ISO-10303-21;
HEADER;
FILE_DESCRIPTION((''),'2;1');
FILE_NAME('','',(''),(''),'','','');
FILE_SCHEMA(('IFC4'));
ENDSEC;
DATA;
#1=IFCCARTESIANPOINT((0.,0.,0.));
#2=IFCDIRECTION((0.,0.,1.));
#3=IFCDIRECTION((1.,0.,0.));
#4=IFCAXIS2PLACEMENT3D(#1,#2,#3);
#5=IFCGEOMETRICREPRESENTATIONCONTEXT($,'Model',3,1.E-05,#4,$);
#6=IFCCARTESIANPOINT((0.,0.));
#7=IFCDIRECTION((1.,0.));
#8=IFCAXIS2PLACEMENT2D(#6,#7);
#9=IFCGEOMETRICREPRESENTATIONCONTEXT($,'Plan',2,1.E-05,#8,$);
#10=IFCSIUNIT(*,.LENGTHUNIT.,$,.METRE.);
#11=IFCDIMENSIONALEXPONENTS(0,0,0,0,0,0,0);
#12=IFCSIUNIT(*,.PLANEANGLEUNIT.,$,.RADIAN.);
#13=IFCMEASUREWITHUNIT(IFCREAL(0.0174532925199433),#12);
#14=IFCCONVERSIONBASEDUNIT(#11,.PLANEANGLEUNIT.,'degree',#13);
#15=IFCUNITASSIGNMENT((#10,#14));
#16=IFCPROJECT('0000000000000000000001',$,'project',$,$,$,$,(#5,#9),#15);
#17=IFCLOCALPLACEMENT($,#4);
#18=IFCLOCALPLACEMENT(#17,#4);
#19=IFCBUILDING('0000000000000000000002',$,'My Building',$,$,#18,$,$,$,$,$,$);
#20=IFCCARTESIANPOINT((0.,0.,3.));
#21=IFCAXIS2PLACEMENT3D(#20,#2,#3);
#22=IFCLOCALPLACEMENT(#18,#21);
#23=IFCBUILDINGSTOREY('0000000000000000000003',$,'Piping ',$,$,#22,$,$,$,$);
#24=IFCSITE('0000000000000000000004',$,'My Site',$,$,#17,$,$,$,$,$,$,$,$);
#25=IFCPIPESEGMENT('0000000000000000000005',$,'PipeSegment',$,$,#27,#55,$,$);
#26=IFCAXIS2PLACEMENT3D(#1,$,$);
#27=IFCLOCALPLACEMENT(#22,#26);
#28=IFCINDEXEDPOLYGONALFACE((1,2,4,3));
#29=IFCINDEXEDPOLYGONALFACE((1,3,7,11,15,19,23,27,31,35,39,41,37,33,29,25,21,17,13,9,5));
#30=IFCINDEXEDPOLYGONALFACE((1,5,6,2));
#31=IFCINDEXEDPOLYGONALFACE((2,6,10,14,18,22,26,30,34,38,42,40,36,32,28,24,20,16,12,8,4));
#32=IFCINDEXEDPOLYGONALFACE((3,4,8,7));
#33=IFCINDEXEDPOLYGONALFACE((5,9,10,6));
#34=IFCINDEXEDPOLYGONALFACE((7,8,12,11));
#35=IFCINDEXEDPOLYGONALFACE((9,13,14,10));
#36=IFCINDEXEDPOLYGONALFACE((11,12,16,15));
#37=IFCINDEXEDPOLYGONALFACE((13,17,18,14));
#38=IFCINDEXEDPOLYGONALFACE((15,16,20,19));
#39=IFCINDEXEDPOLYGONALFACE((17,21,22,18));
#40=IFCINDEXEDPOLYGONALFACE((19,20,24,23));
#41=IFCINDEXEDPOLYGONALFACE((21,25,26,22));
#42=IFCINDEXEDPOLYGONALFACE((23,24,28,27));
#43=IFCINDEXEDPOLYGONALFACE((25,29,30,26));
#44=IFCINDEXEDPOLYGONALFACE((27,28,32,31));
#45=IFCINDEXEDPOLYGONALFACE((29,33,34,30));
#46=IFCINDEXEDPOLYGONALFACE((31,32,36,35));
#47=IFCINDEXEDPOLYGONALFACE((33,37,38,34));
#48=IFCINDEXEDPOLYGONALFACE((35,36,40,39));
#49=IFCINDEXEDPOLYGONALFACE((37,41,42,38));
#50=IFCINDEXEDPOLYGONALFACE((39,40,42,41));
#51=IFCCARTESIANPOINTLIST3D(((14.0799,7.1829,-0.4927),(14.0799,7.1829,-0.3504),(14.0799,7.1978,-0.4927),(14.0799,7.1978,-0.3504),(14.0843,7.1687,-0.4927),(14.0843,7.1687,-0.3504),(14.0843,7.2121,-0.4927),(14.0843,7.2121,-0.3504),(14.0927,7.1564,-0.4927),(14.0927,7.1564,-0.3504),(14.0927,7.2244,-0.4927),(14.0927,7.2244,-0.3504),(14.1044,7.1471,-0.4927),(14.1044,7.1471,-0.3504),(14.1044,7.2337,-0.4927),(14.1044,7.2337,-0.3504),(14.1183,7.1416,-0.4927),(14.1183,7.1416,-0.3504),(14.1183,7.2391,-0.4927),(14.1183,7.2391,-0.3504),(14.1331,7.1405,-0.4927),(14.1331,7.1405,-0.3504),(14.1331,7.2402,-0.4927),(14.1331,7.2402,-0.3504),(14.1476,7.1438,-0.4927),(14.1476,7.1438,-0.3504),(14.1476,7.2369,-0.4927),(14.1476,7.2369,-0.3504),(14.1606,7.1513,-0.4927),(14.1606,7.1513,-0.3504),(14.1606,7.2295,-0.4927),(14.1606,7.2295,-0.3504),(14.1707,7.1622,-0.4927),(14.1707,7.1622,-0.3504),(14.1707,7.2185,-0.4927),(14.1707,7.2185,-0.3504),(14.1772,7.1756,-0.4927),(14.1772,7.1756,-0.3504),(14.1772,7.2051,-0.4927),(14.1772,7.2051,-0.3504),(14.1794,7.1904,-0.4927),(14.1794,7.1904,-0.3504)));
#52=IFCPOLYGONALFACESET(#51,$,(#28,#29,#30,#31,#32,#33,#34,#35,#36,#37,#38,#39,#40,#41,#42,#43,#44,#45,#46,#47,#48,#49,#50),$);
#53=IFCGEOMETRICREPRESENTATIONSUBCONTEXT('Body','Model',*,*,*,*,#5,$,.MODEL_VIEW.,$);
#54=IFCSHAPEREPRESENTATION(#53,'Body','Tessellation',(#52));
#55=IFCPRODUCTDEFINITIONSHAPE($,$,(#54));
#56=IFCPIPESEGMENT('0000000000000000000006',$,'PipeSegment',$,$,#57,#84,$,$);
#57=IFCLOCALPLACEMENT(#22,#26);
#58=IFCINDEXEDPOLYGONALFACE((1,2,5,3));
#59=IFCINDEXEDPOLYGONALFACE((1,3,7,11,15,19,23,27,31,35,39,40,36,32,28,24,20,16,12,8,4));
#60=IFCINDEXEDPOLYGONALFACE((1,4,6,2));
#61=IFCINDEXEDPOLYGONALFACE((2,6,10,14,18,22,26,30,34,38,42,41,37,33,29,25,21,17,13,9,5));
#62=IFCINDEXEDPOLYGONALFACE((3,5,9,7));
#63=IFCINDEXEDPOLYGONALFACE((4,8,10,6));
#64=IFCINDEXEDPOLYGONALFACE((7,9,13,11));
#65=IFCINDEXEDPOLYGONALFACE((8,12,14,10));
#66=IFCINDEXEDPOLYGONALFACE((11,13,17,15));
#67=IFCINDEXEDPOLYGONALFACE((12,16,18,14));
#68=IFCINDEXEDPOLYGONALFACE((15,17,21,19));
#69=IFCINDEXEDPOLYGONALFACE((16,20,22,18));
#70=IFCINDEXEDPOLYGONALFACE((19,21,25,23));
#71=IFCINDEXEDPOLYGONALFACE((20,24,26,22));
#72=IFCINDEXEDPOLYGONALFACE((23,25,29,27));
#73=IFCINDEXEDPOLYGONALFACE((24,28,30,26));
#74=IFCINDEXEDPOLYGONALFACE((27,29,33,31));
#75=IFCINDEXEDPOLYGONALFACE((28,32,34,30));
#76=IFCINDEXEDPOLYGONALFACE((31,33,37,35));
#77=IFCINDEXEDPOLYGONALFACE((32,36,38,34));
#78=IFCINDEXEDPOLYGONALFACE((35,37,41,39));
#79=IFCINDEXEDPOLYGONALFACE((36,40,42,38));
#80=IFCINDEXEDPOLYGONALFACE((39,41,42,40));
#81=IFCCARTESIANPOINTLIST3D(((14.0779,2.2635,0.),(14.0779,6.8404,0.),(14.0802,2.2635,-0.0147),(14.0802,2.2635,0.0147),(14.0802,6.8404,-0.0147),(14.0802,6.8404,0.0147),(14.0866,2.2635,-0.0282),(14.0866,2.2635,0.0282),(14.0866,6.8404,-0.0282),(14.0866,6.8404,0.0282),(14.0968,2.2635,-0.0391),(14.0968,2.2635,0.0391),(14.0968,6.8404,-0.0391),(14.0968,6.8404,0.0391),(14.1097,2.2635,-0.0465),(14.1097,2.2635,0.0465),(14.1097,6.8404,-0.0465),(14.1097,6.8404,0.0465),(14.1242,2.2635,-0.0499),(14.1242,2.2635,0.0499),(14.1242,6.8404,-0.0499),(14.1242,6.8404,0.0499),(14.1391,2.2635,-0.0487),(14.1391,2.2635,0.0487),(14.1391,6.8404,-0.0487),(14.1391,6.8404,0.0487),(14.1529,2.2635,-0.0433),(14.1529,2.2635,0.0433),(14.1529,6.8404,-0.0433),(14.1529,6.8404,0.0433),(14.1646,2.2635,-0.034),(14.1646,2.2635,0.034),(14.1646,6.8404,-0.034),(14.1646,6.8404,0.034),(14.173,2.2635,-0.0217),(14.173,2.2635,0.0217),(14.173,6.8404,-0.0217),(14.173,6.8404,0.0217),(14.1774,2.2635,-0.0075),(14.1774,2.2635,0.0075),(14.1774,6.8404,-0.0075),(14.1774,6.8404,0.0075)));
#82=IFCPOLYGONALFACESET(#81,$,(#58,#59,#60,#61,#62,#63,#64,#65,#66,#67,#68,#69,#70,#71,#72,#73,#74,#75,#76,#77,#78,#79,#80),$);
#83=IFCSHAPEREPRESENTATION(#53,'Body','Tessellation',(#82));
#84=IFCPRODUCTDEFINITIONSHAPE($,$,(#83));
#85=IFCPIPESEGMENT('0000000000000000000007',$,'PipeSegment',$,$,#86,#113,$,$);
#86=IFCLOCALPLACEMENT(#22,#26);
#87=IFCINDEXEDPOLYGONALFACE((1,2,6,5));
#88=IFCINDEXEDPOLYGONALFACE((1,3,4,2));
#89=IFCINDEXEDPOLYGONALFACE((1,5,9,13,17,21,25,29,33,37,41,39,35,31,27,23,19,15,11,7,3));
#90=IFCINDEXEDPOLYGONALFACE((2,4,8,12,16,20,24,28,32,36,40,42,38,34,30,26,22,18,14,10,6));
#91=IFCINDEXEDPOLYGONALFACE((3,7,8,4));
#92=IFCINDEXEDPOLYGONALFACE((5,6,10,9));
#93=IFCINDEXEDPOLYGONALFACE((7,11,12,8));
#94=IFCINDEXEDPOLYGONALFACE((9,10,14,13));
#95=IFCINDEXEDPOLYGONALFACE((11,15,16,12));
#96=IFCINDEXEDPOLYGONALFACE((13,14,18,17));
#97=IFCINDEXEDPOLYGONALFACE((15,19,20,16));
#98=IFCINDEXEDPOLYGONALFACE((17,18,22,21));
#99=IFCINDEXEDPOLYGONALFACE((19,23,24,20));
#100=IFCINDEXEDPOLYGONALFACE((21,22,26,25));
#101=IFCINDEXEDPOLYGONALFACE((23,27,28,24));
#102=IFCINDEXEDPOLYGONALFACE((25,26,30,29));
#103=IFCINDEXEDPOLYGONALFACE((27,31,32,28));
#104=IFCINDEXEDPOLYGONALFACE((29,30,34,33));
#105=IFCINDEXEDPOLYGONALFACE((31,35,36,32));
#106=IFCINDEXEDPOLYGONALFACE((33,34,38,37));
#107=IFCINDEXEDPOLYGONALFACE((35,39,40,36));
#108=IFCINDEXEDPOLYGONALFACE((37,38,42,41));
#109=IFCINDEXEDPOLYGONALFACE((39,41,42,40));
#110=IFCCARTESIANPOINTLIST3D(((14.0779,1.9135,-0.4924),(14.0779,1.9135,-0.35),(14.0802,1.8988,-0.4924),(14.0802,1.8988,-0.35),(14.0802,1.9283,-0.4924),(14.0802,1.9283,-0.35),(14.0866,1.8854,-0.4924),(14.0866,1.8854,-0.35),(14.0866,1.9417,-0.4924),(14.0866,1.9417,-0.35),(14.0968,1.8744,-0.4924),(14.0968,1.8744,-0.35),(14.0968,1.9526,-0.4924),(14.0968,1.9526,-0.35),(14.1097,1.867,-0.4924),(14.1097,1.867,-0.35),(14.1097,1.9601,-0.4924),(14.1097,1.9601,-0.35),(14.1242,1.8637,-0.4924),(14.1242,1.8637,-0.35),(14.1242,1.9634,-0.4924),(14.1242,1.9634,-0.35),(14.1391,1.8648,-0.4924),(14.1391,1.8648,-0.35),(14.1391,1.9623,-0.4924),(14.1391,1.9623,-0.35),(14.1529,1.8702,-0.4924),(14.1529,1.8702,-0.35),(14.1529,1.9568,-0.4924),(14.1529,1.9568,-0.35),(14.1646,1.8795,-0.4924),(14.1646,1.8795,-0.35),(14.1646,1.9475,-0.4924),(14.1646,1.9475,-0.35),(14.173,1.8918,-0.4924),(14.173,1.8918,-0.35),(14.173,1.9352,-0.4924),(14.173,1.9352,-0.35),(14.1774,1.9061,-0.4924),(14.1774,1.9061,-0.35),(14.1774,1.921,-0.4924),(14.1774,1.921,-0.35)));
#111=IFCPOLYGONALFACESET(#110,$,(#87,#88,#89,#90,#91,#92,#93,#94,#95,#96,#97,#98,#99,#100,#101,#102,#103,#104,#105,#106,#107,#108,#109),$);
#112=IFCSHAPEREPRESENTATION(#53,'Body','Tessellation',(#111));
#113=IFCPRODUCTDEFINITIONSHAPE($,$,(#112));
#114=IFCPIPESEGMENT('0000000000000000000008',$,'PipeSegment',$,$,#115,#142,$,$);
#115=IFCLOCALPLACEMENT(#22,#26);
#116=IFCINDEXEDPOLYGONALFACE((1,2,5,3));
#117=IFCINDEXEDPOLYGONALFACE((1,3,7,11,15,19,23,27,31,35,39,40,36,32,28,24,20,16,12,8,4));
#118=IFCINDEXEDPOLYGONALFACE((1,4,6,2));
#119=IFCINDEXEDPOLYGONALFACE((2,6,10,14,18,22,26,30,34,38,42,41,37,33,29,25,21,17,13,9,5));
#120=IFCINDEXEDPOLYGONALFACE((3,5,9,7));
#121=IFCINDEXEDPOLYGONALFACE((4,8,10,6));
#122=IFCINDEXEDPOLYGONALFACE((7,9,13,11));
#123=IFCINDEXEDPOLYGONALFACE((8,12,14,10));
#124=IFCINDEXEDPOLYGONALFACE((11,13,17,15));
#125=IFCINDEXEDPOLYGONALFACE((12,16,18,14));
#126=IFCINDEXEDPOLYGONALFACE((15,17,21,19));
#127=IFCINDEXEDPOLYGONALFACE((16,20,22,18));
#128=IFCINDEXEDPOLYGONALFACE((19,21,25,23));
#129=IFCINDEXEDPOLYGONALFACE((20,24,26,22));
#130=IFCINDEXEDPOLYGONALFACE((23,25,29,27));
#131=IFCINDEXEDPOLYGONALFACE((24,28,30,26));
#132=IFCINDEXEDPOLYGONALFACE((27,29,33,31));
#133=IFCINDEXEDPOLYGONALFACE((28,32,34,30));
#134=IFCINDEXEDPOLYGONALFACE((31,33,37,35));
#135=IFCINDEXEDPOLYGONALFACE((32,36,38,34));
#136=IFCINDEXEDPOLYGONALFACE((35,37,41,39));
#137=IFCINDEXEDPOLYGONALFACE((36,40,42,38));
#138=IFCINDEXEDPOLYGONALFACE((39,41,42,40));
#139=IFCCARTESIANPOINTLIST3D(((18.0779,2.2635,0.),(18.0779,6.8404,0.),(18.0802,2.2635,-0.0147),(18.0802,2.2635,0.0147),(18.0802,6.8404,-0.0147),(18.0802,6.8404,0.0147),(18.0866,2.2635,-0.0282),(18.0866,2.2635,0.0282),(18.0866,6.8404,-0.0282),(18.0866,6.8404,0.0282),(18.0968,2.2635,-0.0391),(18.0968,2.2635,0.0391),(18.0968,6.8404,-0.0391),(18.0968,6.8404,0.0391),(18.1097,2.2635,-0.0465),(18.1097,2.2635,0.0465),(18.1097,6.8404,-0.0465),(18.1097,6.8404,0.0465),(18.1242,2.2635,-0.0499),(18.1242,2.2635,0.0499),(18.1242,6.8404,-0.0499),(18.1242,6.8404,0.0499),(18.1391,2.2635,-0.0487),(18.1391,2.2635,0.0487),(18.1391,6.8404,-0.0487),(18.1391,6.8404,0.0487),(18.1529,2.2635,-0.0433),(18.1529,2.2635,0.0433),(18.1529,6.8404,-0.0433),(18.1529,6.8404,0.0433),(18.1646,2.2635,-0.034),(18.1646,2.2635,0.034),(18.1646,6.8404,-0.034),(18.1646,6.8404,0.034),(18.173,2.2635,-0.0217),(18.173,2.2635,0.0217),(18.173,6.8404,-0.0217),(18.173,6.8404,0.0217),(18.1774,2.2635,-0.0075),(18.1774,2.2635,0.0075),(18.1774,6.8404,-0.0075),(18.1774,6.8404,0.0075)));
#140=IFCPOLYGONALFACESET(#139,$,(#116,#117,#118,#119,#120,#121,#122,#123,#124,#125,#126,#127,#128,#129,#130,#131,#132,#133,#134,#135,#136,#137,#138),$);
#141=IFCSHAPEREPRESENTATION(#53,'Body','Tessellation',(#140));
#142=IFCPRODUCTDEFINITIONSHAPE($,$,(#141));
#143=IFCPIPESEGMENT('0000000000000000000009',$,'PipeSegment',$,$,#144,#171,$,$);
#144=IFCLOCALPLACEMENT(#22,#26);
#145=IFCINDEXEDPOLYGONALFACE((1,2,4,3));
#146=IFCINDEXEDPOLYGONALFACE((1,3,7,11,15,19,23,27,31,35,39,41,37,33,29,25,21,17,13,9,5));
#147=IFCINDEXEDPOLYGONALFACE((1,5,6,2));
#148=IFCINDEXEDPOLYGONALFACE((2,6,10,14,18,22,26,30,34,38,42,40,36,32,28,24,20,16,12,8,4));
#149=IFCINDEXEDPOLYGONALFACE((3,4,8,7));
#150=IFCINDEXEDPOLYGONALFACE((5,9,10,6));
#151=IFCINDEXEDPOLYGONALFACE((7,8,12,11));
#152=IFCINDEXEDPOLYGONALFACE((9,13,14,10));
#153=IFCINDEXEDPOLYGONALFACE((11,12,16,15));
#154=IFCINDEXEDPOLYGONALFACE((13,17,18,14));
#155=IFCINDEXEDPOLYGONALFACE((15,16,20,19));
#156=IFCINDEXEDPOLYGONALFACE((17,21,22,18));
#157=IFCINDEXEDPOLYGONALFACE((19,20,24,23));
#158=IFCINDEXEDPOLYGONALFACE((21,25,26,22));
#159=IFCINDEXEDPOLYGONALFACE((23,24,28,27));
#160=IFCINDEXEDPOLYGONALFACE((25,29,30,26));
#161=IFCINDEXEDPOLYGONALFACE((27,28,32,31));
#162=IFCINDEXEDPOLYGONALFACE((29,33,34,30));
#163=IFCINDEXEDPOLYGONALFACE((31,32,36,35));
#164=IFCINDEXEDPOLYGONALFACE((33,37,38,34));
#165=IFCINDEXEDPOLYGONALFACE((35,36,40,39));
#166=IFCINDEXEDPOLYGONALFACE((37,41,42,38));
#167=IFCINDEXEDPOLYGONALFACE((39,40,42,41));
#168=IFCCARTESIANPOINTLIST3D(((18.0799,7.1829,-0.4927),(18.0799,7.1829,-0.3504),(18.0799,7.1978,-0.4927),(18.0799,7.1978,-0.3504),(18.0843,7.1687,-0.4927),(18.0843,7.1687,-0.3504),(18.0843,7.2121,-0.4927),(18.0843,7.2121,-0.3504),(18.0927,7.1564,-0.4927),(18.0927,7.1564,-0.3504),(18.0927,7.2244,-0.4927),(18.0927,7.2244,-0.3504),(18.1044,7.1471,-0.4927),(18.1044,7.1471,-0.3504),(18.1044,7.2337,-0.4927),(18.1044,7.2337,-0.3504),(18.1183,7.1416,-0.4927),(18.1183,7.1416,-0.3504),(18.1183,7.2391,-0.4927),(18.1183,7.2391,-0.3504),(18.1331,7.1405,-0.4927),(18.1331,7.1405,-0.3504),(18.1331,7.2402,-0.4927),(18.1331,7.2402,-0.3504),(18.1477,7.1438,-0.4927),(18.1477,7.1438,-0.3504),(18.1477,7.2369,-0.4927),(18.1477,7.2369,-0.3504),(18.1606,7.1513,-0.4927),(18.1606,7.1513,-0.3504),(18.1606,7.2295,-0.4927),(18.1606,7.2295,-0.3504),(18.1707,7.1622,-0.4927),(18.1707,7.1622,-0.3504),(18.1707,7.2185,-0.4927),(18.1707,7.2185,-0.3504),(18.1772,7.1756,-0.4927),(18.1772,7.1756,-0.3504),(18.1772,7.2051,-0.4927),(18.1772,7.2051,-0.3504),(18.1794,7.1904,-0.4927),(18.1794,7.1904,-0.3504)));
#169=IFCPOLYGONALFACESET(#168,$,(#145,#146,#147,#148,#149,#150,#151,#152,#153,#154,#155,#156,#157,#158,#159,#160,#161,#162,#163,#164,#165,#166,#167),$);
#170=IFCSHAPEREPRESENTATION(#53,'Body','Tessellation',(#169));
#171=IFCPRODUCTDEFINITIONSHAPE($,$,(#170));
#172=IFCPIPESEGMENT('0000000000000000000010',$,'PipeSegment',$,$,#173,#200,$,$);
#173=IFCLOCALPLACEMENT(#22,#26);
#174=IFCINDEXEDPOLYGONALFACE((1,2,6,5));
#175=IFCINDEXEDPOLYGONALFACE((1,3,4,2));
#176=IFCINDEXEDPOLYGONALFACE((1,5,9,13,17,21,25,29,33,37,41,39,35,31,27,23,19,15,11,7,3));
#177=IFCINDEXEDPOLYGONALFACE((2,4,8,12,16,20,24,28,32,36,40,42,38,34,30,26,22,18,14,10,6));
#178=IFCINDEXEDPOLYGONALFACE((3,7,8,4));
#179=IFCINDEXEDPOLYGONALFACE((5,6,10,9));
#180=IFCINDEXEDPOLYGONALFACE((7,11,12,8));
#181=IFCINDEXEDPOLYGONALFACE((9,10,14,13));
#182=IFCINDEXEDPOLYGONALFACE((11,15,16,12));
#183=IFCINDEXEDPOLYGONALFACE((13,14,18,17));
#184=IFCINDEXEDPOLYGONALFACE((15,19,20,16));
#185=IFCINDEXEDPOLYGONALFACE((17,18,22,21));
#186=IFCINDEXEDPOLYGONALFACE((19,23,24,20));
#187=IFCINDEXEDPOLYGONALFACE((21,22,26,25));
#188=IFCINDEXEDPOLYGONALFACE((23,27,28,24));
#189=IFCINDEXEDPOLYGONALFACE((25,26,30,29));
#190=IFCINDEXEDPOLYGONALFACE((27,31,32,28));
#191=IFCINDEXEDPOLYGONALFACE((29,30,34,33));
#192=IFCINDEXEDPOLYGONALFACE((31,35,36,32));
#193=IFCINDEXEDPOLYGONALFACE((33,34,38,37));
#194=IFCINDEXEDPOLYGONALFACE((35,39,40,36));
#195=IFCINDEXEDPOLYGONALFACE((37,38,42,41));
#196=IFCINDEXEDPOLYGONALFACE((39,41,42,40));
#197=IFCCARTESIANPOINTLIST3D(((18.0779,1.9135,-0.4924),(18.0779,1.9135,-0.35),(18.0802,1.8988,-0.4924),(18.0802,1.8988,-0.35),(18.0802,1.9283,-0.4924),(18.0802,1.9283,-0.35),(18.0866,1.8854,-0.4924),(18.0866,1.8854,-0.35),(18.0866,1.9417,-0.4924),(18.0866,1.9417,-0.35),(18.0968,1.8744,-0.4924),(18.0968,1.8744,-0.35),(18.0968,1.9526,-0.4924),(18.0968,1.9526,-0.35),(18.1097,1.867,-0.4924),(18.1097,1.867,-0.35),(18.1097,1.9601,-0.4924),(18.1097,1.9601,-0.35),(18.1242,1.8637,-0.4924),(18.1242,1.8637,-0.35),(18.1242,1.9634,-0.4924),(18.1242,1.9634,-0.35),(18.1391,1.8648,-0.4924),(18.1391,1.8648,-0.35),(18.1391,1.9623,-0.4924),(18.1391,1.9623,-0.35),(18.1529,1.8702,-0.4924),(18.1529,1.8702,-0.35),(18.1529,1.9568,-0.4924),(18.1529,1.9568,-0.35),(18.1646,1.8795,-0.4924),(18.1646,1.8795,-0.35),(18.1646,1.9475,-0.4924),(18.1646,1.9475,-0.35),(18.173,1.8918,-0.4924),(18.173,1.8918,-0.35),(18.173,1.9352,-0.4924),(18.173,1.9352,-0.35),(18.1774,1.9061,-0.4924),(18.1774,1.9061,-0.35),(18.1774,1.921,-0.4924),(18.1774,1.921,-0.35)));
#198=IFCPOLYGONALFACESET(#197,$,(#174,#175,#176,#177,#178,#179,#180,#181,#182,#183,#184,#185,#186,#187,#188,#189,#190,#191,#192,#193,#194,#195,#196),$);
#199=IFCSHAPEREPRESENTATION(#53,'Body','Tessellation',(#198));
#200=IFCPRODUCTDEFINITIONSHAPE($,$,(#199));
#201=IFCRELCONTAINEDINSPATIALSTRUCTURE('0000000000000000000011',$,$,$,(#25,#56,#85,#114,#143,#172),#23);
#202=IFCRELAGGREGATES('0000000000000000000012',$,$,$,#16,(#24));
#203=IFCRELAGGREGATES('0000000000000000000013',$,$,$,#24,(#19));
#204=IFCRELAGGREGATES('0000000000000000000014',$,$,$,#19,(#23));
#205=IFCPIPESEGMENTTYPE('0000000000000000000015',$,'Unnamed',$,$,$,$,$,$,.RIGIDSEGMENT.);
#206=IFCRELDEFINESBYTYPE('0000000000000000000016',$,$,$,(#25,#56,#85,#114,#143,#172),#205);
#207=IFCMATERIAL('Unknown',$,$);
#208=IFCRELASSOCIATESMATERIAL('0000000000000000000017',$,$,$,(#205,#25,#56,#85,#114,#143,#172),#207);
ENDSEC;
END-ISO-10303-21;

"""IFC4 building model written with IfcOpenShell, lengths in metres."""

from ifc_helpers import new_model, entity, si_unit, converted_unit, frame, origin_with_axes, origin_2d_with_axis, place, context, subcontext, project, spatial, circle, extrude, material, material_profile, profile_set, profile_usage, type_object, element, save


model = new_model("IFC4")

# Units and contexts
model_context = context("Model", 3, precision=1e-05, world=origin_with_axes())
plan_context = context("Plan", 2, precision=1e-05, world=origin_2d_with_axis())
body_context = subcontext(model_context, "Body", "Model", "MODEL_VIEW")
ifc_project = project(units=[si_unit("LENGTHUNIT", "METRE"), converted_unit("PLANEANGLEUNIT", "degree", entity("IfcReal", 0.0174532925199433), si_unit("PLANEANGLEUNIT", "RADIAN"), dimensions=[0, 0, 0, 0, 0, 0, 0])], contexts=[model_context, plan_context])

# Site, building, storey
site_placement = place(None, origin_with_axes())
site = spatial("IfcSite", under=ifc_project, at=site_placement, Name="My Site")
building_placement = place(site_placement, origin_with_axes())
building = spatial("IfcBuilding", under=site, at=building_placement, Name="My Building")
storey_placement = place(building_placement, frame((0.0, 0.0, 3.0), z_axis=(0.0, 0.0, 1.0), x_axis=(1.0, 0.0, 0.0)))
storey = spatial("IfcBuildingStorey", under=building, at=storey_placement, Name="Piping ")

# Pipe segments
ifc_material = material(Name="Unknown")
ifc_material_profile = material_profile(ifc_material, circle(Radius=0.05))
ifc_profile_set = profile_set([ifc_material_profile])
pipe_segment_type = type_object("IfcPipeSegmentType", Name="Unnamed", PredefinedType="RIGIDSEGMENT", material=ifc_profile_set)
ifc_profile_usage_1 = profile_usage(ifc_profile_set, cardinal=5)
pipe_segment_1_placement = place(storey_placement, frame((14.1294, 7.1904, -0.3504), z_axis=(0.0, 0.0, -1.0), x_axis=(1.0, 0.0, 0.0)))
element("IfcPipeSegment", 1, at=pipe_segment_1_placement, inside=storey, type_object=pipe_segment_type, material=ifc_profile_usage_1, Name="PipeSegment", context=body_context, shape_type="SweptSolid", body=[
    extrude(circle(Radius=0.05), origin_with_axes(), (0.0, 0.0, 1.0), 0.1424),
])
ifc_profile_usage_2 = profile_usage(ifc_profile_set, cardinal=5)
pipe_segment_2_placement = place(storey_placement, frame((14.1279, 2.2635, 0.0), z_axis=(0.0, 1.0, 0.0), x_axis=(-1.0, 0.0, 0.0)))
element("IfcPipeSegment", 2, at=pipe_segment_2_placement, inside=storey, type_object=pipe_segment_type, material=ifc_profile_usage_2, Name="PipeSegment", context=body_context, shape_type="SweptSolid", body=[
    extrude(circle(Radius=0.05), origin_with_axes(), (0.0, 0.0, 1.0), 4.5768),
])
ifc_profile_usage_3 = profile_usage(ifc_profile_set, cardinal=5)
pipe_segment_3_placement = place(storey_placement, frame((14.1279, 1.9135, -0.35), z_axis=(0.0, 0.0, -1.0), x_axis=(-1.0, 0.0, 0.0)))
element("IfcPipeSegment", 3, at=pipe_segment_3_placement, inside=storey, type_object=pipe_segment_type, material=ifc_profile_usage_3, Name="PipeSegment", context=body_context, shape_type="SweptSolid", body=[
    extrude(circle(Radius=0.05), origin_with_axes(), (0.0, 0.0, 1.0), 0.1424),
])
ifc_profile_usage_4 = profile_usage(ifc_profile_set, cardinal=5)
pipe_segment_4_placement = place(storey_placement, frame((18.1279, 2.2635, 0.0), z_axis=(0.0, 1.0, 0.0), x_axis=(-1.0, 0.0, 0.0)))
element("IfcPipeSegment", 4, at=pipe_segment_4_placement, inside=storey, type_object=pipe_segment_type, material=ifc_profile_usage_4, Name="PipeSegment", context=body_context, shape_type="SweptSolid", body=[
    extrude(circle(Radius=0.05), origin_with_axes(), (0.0, 0.0, 1.0), 4.5768),
])
ifc_profile_usage_5 = profile_usage(ifc_profile_set, cardinal=5)
pipe_segment_5_placement = place(storey_placement, frame((18.1294, 7.1904, -0.3504), z_axis=(0.0, 0.0, -1.0), x_axis=(1.0, 0.0, 0.0)))
element("IfcPipeSegment", 5, at=pipe_segment_5_placement, inside=storey, type_object=pipe_segment_type, material=ifc_profile_usage_5, Name="PipeSegment", context=body_context, shape_type="SweptSolid", body=[
    extrude(circle(Radius=0.05), origin_with_axes(), (0.0, 0.0, 1.0), 0.1424),
])
ifc_profile_usage_6 = profile_usage(ifc_profile_set, cardinal=5)
pipe_segment_6_placement = place(storey_placement, frame((18.1279, 1.9135, -0.35), z_axis=(0.0, 0.0, -1.0), x_axis=(-1.0, 0.0, 0.0)))
element("IfcPipeSegment", 6, at=pipe_segment_6_placement, inside=storey, type_object=pipe_segment_type, material=ifc_profile_usage_6, Name="PipeSegment", context=body_context, shape_type="SweptSolid", body=[
    extrude(circle(Radius=0.05), origin_with_axes(), (0.0, 0.0, 1.0), 0.1424),
])

save(model, "model.ifc")
